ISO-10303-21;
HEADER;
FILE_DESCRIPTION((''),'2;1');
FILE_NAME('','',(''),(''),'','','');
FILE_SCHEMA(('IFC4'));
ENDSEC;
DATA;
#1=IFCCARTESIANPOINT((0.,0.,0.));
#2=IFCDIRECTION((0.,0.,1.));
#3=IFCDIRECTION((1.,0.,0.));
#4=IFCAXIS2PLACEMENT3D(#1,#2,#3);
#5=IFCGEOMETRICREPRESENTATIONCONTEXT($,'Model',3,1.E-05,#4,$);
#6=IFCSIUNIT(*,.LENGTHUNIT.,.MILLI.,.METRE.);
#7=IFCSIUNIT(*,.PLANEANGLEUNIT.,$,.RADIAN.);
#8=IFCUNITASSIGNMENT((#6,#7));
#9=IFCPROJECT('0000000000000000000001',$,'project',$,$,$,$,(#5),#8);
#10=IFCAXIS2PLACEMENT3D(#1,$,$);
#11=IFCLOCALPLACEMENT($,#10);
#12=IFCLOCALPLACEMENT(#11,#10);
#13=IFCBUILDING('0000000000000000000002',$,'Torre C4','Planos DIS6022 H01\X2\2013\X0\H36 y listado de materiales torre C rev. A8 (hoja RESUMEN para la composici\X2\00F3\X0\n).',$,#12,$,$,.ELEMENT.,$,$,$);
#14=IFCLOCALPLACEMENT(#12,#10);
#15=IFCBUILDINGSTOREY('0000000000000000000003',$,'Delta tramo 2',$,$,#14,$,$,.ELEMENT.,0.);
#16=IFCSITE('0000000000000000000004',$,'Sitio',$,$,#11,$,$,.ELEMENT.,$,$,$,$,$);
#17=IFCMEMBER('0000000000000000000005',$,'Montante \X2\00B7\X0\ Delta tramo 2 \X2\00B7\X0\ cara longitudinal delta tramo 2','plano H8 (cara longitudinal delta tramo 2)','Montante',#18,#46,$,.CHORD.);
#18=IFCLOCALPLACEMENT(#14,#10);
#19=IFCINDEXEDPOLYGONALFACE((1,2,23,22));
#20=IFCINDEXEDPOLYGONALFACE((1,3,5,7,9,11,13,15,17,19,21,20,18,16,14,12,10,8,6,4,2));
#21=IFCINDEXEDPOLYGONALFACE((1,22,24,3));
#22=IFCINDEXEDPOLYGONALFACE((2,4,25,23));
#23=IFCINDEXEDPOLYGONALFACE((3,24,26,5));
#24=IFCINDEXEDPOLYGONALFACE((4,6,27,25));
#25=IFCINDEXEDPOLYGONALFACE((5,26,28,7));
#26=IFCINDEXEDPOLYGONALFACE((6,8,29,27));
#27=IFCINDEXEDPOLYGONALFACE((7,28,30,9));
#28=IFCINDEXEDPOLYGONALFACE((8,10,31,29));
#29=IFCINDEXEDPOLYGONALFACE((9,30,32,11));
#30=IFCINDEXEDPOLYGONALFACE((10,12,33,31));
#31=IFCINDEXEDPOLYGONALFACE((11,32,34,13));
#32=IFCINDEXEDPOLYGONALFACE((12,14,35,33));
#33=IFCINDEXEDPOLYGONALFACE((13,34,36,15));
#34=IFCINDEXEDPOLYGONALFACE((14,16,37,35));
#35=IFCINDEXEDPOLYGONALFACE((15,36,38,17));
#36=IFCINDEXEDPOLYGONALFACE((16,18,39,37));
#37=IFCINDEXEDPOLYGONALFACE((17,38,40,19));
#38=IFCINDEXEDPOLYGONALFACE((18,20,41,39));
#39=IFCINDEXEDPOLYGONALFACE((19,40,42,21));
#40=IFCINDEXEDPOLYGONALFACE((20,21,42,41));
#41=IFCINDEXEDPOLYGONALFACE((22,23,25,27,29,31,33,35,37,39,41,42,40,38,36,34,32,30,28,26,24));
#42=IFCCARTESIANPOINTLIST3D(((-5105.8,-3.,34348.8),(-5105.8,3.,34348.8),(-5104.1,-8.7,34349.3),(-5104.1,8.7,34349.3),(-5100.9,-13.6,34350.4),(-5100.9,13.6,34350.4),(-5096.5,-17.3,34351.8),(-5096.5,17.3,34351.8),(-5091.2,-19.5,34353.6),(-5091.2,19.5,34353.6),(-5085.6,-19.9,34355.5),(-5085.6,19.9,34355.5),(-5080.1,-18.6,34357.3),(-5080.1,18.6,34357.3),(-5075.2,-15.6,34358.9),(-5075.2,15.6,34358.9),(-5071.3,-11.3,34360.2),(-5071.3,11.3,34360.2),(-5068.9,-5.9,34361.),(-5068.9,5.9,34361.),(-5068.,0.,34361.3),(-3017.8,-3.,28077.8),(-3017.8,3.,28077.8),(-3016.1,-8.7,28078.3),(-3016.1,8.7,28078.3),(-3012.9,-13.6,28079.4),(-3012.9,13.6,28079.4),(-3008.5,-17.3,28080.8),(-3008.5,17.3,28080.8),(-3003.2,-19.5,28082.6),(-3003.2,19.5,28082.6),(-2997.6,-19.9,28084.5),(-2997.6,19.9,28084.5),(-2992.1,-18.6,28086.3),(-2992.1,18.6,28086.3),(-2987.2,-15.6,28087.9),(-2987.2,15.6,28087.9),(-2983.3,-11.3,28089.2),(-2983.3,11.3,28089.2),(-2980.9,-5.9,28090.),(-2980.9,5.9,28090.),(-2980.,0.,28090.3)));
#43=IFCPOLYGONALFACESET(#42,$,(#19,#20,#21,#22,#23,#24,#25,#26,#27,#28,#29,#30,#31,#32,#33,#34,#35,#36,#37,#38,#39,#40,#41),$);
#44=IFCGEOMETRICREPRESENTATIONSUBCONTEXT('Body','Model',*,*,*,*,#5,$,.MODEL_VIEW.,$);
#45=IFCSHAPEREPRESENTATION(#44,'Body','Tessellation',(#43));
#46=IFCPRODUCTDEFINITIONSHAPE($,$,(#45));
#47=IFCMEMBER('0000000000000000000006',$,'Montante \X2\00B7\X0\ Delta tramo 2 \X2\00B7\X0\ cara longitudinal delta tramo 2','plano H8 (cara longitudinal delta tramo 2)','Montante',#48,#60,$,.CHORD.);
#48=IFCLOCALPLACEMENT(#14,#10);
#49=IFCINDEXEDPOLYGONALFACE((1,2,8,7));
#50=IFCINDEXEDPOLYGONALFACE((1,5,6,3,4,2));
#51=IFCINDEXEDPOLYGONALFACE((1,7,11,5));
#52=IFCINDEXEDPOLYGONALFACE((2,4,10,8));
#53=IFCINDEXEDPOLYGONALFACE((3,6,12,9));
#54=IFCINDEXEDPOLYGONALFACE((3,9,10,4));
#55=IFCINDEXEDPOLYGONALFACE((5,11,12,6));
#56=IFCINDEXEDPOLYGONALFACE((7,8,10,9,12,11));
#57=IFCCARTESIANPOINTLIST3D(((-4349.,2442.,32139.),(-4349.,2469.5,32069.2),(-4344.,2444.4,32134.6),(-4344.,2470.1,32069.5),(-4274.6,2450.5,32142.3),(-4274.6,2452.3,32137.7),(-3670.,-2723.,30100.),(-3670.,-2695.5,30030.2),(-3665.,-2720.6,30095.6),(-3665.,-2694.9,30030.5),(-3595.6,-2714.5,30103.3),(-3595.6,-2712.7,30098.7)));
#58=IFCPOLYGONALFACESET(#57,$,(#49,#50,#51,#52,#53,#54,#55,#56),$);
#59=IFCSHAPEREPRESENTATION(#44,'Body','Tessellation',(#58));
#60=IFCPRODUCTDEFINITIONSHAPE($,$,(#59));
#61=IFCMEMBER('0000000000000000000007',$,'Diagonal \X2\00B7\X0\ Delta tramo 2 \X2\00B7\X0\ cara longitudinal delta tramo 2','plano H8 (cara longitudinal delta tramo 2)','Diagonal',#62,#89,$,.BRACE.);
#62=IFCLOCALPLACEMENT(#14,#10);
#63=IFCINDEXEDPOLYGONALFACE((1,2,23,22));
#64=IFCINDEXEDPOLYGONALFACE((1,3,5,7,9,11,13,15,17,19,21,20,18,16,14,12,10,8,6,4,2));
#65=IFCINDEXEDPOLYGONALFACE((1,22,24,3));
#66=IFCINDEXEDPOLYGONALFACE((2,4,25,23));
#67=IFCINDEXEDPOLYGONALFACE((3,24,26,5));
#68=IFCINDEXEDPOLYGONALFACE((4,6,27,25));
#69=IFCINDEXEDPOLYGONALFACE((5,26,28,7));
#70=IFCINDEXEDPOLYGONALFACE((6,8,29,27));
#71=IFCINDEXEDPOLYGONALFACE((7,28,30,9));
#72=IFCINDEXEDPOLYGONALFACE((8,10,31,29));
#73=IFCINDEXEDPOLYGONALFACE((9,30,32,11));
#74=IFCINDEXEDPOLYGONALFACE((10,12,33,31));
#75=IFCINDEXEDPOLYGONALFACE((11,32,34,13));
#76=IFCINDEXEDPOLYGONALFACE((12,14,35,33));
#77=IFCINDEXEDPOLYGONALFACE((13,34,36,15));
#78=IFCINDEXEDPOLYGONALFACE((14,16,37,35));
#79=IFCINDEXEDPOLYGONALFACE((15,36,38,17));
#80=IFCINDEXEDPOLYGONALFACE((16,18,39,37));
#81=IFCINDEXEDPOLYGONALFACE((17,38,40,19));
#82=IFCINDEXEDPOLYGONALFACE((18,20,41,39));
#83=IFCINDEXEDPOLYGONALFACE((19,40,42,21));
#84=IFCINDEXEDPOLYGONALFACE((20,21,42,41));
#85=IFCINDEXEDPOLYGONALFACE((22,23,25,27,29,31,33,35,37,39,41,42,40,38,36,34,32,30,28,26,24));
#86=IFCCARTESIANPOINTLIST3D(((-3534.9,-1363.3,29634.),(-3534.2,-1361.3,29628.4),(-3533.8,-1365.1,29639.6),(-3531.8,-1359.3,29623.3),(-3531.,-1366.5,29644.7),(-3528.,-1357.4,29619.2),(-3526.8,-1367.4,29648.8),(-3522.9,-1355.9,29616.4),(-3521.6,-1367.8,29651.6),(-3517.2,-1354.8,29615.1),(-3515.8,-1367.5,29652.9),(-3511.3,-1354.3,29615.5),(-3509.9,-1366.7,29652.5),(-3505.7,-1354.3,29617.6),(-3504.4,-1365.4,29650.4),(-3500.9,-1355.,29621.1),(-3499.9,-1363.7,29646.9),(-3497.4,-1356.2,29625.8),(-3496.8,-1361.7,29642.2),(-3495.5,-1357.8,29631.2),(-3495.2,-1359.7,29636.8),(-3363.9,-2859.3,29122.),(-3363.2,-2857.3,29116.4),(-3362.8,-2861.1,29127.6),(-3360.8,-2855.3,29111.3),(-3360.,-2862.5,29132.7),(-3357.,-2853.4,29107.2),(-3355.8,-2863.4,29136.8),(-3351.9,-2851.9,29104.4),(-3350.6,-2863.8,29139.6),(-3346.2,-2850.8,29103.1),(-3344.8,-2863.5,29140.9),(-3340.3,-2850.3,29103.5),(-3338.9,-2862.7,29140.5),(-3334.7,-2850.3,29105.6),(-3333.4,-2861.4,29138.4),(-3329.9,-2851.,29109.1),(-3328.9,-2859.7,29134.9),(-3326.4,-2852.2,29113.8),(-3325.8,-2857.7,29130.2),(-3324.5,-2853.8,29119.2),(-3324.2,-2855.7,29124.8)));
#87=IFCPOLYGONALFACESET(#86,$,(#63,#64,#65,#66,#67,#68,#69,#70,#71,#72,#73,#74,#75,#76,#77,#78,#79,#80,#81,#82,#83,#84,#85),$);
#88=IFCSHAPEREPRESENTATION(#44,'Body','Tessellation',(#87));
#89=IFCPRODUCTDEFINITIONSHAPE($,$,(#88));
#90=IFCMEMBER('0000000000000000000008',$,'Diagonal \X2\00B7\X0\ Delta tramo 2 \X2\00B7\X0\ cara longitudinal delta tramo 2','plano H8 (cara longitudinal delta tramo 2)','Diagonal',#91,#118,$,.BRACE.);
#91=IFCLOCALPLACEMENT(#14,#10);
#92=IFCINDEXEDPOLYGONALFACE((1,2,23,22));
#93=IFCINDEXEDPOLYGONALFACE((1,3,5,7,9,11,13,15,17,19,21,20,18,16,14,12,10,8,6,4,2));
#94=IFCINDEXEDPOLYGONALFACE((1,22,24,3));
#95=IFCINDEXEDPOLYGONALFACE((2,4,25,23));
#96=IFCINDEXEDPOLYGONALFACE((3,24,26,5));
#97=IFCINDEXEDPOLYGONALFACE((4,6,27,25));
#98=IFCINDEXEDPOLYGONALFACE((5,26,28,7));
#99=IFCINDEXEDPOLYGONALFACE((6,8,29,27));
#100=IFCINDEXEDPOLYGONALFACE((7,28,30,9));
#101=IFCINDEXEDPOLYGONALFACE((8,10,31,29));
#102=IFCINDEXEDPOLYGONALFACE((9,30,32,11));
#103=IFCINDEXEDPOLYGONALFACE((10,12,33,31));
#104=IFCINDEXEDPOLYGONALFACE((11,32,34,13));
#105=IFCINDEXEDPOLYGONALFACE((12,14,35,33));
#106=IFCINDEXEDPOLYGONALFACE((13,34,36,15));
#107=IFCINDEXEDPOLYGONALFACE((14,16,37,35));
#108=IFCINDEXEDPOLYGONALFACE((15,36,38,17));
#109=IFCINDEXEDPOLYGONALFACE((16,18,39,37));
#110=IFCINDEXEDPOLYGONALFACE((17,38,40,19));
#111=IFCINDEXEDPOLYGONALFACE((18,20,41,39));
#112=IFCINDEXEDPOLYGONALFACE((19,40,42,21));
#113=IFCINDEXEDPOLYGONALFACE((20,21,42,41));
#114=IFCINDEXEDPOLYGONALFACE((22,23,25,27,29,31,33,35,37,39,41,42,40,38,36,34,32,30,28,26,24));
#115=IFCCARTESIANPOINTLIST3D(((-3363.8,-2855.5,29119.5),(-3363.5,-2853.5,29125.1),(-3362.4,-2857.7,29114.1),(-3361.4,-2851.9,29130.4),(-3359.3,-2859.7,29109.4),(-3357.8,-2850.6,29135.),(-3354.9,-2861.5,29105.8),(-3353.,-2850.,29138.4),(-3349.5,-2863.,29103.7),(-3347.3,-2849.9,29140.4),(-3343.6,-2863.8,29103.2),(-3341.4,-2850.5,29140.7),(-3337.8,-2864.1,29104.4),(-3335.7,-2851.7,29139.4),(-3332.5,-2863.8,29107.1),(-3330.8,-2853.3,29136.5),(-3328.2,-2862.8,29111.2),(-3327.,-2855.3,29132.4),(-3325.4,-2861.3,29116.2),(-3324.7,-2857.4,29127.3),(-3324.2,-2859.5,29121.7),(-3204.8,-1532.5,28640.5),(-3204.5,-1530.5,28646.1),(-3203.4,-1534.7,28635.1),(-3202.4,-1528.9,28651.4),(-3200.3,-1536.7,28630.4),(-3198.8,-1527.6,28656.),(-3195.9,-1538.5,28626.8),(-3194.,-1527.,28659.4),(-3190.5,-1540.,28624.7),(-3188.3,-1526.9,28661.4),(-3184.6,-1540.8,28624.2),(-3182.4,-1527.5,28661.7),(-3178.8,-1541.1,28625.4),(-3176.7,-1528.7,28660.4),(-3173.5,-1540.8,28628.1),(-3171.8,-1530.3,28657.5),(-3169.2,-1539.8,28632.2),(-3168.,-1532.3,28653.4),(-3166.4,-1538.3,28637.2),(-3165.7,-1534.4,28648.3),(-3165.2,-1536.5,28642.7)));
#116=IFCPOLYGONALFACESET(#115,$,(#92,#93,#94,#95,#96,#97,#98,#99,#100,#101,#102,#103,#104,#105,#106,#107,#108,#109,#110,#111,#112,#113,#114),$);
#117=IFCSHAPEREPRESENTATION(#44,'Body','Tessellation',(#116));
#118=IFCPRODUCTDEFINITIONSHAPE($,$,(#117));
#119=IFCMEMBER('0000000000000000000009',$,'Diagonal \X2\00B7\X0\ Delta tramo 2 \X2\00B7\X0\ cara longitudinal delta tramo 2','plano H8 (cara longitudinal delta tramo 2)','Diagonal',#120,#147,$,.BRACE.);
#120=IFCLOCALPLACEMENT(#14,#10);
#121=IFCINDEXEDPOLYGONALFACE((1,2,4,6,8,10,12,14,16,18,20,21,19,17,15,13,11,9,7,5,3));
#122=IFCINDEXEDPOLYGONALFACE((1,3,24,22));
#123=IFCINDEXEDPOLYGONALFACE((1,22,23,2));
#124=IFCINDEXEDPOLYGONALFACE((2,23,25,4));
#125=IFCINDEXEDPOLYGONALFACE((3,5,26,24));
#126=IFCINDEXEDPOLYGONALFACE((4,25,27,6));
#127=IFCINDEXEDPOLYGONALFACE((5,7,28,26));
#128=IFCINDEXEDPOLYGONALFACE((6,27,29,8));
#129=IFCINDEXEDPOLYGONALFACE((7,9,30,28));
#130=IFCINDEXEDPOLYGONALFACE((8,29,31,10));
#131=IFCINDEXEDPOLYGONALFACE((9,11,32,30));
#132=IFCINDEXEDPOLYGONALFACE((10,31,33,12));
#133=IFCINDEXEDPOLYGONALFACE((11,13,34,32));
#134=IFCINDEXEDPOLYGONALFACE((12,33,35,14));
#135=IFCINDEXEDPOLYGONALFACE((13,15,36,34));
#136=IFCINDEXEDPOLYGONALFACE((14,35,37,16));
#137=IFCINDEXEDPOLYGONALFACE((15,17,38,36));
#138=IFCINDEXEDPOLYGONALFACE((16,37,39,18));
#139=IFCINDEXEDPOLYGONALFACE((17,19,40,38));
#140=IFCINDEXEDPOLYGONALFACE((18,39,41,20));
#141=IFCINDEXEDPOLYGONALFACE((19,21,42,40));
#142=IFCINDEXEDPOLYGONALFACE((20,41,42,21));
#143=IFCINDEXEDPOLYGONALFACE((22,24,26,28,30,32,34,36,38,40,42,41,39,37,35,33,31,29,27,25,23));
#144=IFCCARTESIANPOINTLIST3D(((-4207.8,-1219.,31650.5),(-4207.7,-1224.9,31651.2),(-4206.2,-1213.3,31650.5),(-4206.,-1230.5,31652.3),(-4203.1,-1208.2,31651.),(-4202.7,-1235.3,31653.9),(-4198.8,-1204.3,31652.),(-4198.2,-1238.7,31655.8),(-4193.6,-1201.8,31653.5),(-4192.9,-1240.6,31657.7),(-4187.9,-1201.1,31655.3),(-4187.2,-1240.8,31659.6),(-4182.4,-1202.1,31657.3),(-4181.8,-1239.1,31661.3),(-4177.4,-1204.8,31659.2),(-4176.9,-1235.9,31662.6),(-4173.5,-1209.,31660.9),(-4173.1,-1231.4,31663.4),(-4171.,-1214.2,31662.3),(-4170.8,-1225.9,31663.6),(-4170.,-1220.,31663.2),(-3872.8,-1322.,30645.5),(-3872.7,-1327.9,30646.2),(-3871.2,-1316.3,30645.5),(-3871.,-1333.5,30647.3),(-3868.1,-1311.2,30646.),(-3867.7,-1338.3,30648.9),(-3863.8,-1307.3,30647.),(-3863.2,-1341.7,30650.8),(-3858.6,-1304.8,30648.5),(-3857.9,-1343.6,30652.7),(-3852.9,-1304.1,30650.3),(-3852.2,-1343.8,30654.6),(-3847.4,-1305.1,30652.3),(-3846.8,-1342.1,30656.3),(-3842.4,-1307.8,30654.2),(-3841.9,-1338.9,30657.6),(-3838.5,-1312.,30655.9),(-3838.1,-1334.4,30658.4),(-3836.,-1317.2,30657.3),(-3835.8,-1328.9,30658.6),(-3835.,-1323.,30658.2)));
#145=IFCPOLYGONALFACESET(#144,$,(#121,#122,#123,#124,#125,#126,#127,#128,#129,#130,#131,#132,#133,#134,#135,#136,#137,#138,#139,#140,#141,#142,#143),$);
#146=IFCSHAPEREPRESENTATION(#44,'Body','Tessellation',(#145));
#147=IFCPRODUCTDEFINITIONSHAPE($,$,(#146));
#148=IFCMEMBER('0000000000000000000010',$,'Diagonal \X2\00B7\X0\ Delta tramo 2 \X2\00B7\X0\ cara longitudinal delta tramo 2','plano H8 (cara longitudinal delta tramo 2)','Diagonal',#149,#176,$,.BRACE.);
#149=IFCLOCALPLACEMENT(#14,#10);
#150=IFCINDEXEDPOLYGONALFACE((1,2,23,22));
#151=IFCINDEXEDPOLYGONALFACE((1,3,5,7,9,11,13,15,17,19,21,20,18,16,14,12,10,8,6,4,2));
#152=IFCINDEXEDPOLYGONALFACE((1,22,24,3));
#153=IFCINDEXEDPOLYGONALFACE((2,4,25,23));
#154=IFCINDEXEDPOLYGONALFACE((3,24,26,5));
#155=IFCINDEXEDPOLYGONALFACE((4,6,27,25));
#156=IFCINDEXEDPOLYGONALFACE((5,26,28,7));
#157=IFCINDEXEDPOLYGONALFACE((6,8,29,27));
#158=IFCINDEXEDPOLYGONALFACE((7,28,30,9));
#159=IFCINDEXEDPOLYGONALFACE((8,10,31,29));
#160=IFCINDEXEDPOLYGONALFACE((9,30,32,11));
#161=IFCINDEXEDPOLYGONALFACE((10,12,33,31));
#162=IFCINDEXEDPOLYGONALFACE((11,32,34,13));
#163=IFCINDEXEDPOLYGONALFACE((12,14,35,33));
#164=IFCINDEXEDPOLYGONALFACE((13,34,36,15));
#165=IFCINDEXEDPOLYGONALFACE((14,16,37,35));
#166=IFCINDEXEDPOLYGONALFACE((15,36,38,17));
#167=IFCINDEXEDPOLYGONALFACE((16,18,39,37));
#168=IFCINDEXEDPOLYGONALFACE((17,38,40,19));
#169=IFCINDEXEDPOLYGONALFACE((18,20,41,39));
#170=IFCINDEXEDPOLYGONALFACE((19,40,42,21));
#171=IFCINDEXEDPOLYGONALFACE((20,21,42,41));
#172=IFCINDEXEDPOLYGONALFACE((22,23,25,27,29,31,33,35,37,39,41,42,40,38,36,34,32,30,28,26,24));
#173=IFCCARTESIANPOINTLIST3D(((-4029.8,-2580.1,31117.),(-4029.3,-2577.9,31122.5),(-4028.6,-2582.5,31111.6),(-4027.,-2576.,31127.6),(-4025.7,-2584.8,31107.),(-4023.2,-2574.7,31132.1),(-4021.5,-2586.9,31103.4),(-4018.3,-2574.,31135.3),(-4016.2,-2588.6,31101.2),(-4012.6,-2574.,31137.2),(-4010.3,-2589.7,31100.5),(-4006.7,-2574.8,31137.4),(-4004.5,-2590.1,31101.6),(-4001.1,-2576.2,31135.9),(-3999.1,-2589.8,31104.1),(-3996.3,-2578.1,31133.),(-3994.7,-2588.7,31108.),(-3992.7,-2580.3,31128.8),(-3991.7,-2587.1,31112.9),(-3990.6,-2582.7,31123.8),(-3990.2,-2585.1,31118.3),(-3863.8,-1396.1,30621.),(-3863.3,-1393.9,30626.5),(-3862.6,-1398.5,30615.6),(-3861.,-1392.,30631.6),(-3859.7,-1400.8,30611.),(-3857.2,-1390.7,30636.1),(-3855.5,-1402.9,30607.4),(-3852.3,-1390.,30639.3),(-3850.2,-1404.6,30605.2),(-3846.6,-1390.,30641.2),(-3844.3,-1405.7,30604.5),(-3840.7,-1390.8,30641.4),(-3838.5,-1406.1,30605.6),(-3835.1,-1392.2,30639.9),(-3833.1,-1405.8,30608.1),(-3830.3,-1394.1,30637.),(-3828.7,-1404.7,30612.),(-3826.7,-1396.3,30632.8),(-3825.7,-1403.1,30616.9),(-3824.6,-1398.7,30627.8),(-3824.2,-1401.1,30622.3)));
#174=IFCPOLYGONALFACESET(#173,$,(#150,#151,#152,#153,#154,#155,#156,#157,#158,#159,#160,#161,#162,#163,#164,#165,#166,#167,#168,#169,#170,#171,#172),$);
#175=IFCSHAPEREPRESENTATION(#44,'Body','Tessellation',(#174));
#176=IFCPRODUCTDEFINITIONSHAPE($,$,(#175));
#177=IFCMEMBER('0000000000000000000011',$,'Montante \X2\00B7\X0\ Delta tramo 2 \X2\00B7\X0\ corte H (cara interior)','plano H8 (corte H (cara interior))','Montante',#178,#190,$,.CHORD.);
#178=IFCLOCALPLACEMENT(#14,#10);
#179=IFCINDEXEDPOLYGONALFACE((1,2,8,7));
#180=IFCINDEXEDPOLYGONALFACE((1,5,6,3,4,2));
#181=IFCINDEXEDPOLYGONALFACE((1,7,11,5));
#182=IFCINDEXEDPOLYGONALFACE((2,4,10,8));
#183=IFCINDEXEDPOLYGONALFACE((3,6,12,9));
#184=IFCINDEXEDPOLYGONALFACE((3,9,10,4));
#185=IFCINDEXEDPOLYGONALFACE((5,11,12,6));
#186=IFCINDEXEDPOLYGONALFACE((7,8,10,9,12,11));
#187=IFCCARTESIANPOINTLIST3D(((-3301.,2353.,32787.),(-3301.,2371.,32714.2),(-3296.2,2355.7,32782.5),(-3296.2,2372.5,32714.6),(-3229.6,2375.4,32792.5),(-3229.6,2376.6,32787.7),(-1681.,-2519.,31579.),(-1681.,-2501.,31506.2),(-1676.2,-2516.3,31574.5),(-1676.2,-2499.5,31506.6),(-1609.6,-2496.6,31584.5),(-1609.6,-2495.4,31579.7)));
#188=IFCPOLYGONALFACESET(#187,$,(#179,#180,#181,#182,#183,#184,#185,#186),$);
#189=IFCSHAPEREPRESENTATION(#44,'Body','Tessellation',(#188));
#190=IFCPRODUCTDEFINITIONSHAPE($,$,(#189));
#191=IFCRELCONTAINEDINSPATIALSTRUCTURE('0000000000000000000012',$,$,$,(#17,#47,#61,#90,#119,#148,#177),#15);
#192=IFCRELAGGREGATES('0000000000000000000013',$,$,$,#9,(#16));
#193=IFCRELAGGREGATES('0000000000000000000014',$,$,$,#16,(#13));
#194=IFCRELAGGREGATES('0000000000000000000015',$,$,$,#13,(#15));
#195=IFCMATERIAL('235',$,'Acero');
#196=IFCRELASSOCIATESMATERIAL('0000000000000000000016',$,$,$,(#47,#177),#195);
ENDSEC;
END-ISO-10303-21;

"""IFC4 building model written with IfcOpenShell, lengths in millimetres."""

from ifc_helpers import new_model, si_unit, frame, frame_2d, origin, origin_with_axes, place, context, subcontext, project, spatial, circle, l_section, extrude, material, element, save


model = new_model("IFC4")

# Units and contexts
model_context = context("Model", 3, precision=1e-05, world=origin_with_axes())
body_context = subcontext(model_context, "Body", "Model", "MODEL_VIEW")
ifc_project = project(units=[si_unit("LENGTHUNIT", "METRE", prefix="MILLI"), si_unit("PLANEANGLEUNIT", "RADIAN")], contexts=[model_context])

# Site, building, storey
site_placement = place(None, origin())
site = spatial("IfcSite", under=ifc_project, at=site_placement, Name="Sitio", CompositionType="ELEMENT")
building_placement = place(site_placement, origin())
building = spatial("IfcBuilding", under=site, at=building_placement, Name="Torre C4", Description="Planos DIS6022 H01–H36 y listado de materiales torre C rev. A8 (hoja RESUMEN para la composición).", CompositionType="ELEMENT")
storey_placement = place(building_placement, origin())
storey = spatial("IfcBuildingStorey", under=building, at=storey_placement, Name="Delta tramo 2", CompositionType="ELEMENT", Elevation=0.0)

# Members
member_1_placement = place(storey_placement, frame((-2999.0, 0.0, 28084.0), z_axis=(-0.31591, 0.0, 0.948789), x_axis=(0.948789, 0.0, 0.31591)))
element("IfcMember", 1, at=member_1_placement, inside=storey, Name="Montante · Delta tramo 2 · cara longitudinal delta tramo 2", Description="plano H8 (cara longitudinal delta tramo 2)", ObjectType="Montante", PredefinedType="CHORD", context=body_context, shape_type="SweptSolid", body=[
    extrude(circle(Radius=20.0), None, (0.0, 0.0, 1.0), 6609.5),
])
ifc_material = material(Name="235", Category="Acero")
member_2_placement = place(storey_placement, frame((-3670.0, -2723.0, 30100.0), z_axis=(-0.121374, 0.923267, 0.36448), x_axis=(0.992607, 0.112896, 0.044568)))
element("IfcMember", 2, at=member_2_placement, inside=storey, material=ifc_material, Name="Montante · Delta tramo 2 · cara longitudinal delta tramo 2", Description="plano H8 (cara longitudinal delta tramo 2)", ObjectType="Montante", PredefinedType="CHORD", context=body_context, shape_type="SweptSolid", body=[
    extrude(l_section(Depth=75.0, Width=75.0, Thickness=5.0, at=frame_2d((37.5, 37.5))), None, (0.0, 0.0, 1.0), 5594.3),
])
member_3_placement = place(storey_placement, frame((-3515.0, -1361.0, 29634.0), z_axis=(0.10752, -0.940639, -0.32193), x_axis=(0.977009, 0.159928, -0.140983)))
element("IfcMember", 3, at=member_3_placement, inside=storey, Name="Diagonal · Delta tramo 2 · cara longitudinal delta tramo 2", Description="plano H8 (cara longitudinal delta tramo 2)", ObjectType="Diagonal", PredefinedType="BRACE", context=body_context, shape_type="SweptSolid", body=[
    extrude(circle(Radius=20.0), None, (0.0, 0.0, 1.0), 1590.4),
])
member_4_placement = place(storey_placement, frame((-3344.0, -2857.0, 29122.0), z_axis=(0.112288, 0.934323, -0.338277), x_axis=(0.964427, -0.020485, 0.263553)))
element("IfcMember", 4, at=member_4_placement, inside=storey, Name="Diagonal · Delta tramo 2 · cara longitudinal delta tramo 2", Description="plano H8 (cara longitudinal delta tramo 2)", ObjectType="Diagonal", PredefinedType="BRACE", context=body_context, shape_type="SweptSolid", body=[
    extrude(circle(Radius=20.0), None, (0.0, 0.0, 1.0), 1416.0),
])
member_5_placement = place(storey_placement, frame((-3854.0, -1324.0, 30652.0), z_axis=(-0.314744, 0.096772, 0.944231), x_axis=(0.901869, 0.340631, 0.265712)))
element("IfcMember", 5, at=member_5_placement, inside=storey, Name="Diagonal · Delta tramo 2 · cara longitudinal delta tramo 2", Description="plano H8 (cara longitudinal delta tramo 2)", ObjectType="Diagonal", PredefinedType="BRACE", context=body_context, shape_type="SweptSolid", body=[
    extrude(circle(Radius=20.0), None, (0.0, 0.0, 1.0), 1064.4),
])
member_6_placement = place(storey_placement, frame((-4010.0, -2582.0, 31119.0), z_axis=(0.128246, 0.914721, -0.383194), x_axis=(0.970547, -0.036302, 0.238162)))
element("IfcMember", 6, at=member_6_placement, inside=storey, Name="Diagonal · Delta tramo 2 · cara longitudinal delta tramo 2", Description="plano H8 (cara longitudinal delta tramo 2)", ObjectType="Diagonal", PredefinedType="BRACE", context=body_context, shape_type="SweptSolid", body=[
    extrude(circle(Radius=20.0), None, (0.0, 0.0, 1.0), 1294.4),
])
member_7_placement = place(storey_placement, frame((-1681.0, -2519.0, 31579.0), z_axis=(-0.30714, 0.923694, 0.229028), x_axis=(0.951664, 0.298113, 0.073916)))
element("IfcMember", 7, at=member_7_placement, inside=storey, material=ifc_material, Name="Montante · Delta tramo 2 · corte H (cara interior)", Description="plano H8 (corte H (cara interior))", ObjectType="Montante", PredefinedType="CHORD", context=body_context, shape_type="SweptSolid", body=[
    extrude(l_section(Depth=75.0, Width=75.0, Thickness=5.0, at=frame_2d((37.5, 37.5))), None, (0.0, 0.0, 1.0), 5274.5),
])

save(model, "model.ifc")
